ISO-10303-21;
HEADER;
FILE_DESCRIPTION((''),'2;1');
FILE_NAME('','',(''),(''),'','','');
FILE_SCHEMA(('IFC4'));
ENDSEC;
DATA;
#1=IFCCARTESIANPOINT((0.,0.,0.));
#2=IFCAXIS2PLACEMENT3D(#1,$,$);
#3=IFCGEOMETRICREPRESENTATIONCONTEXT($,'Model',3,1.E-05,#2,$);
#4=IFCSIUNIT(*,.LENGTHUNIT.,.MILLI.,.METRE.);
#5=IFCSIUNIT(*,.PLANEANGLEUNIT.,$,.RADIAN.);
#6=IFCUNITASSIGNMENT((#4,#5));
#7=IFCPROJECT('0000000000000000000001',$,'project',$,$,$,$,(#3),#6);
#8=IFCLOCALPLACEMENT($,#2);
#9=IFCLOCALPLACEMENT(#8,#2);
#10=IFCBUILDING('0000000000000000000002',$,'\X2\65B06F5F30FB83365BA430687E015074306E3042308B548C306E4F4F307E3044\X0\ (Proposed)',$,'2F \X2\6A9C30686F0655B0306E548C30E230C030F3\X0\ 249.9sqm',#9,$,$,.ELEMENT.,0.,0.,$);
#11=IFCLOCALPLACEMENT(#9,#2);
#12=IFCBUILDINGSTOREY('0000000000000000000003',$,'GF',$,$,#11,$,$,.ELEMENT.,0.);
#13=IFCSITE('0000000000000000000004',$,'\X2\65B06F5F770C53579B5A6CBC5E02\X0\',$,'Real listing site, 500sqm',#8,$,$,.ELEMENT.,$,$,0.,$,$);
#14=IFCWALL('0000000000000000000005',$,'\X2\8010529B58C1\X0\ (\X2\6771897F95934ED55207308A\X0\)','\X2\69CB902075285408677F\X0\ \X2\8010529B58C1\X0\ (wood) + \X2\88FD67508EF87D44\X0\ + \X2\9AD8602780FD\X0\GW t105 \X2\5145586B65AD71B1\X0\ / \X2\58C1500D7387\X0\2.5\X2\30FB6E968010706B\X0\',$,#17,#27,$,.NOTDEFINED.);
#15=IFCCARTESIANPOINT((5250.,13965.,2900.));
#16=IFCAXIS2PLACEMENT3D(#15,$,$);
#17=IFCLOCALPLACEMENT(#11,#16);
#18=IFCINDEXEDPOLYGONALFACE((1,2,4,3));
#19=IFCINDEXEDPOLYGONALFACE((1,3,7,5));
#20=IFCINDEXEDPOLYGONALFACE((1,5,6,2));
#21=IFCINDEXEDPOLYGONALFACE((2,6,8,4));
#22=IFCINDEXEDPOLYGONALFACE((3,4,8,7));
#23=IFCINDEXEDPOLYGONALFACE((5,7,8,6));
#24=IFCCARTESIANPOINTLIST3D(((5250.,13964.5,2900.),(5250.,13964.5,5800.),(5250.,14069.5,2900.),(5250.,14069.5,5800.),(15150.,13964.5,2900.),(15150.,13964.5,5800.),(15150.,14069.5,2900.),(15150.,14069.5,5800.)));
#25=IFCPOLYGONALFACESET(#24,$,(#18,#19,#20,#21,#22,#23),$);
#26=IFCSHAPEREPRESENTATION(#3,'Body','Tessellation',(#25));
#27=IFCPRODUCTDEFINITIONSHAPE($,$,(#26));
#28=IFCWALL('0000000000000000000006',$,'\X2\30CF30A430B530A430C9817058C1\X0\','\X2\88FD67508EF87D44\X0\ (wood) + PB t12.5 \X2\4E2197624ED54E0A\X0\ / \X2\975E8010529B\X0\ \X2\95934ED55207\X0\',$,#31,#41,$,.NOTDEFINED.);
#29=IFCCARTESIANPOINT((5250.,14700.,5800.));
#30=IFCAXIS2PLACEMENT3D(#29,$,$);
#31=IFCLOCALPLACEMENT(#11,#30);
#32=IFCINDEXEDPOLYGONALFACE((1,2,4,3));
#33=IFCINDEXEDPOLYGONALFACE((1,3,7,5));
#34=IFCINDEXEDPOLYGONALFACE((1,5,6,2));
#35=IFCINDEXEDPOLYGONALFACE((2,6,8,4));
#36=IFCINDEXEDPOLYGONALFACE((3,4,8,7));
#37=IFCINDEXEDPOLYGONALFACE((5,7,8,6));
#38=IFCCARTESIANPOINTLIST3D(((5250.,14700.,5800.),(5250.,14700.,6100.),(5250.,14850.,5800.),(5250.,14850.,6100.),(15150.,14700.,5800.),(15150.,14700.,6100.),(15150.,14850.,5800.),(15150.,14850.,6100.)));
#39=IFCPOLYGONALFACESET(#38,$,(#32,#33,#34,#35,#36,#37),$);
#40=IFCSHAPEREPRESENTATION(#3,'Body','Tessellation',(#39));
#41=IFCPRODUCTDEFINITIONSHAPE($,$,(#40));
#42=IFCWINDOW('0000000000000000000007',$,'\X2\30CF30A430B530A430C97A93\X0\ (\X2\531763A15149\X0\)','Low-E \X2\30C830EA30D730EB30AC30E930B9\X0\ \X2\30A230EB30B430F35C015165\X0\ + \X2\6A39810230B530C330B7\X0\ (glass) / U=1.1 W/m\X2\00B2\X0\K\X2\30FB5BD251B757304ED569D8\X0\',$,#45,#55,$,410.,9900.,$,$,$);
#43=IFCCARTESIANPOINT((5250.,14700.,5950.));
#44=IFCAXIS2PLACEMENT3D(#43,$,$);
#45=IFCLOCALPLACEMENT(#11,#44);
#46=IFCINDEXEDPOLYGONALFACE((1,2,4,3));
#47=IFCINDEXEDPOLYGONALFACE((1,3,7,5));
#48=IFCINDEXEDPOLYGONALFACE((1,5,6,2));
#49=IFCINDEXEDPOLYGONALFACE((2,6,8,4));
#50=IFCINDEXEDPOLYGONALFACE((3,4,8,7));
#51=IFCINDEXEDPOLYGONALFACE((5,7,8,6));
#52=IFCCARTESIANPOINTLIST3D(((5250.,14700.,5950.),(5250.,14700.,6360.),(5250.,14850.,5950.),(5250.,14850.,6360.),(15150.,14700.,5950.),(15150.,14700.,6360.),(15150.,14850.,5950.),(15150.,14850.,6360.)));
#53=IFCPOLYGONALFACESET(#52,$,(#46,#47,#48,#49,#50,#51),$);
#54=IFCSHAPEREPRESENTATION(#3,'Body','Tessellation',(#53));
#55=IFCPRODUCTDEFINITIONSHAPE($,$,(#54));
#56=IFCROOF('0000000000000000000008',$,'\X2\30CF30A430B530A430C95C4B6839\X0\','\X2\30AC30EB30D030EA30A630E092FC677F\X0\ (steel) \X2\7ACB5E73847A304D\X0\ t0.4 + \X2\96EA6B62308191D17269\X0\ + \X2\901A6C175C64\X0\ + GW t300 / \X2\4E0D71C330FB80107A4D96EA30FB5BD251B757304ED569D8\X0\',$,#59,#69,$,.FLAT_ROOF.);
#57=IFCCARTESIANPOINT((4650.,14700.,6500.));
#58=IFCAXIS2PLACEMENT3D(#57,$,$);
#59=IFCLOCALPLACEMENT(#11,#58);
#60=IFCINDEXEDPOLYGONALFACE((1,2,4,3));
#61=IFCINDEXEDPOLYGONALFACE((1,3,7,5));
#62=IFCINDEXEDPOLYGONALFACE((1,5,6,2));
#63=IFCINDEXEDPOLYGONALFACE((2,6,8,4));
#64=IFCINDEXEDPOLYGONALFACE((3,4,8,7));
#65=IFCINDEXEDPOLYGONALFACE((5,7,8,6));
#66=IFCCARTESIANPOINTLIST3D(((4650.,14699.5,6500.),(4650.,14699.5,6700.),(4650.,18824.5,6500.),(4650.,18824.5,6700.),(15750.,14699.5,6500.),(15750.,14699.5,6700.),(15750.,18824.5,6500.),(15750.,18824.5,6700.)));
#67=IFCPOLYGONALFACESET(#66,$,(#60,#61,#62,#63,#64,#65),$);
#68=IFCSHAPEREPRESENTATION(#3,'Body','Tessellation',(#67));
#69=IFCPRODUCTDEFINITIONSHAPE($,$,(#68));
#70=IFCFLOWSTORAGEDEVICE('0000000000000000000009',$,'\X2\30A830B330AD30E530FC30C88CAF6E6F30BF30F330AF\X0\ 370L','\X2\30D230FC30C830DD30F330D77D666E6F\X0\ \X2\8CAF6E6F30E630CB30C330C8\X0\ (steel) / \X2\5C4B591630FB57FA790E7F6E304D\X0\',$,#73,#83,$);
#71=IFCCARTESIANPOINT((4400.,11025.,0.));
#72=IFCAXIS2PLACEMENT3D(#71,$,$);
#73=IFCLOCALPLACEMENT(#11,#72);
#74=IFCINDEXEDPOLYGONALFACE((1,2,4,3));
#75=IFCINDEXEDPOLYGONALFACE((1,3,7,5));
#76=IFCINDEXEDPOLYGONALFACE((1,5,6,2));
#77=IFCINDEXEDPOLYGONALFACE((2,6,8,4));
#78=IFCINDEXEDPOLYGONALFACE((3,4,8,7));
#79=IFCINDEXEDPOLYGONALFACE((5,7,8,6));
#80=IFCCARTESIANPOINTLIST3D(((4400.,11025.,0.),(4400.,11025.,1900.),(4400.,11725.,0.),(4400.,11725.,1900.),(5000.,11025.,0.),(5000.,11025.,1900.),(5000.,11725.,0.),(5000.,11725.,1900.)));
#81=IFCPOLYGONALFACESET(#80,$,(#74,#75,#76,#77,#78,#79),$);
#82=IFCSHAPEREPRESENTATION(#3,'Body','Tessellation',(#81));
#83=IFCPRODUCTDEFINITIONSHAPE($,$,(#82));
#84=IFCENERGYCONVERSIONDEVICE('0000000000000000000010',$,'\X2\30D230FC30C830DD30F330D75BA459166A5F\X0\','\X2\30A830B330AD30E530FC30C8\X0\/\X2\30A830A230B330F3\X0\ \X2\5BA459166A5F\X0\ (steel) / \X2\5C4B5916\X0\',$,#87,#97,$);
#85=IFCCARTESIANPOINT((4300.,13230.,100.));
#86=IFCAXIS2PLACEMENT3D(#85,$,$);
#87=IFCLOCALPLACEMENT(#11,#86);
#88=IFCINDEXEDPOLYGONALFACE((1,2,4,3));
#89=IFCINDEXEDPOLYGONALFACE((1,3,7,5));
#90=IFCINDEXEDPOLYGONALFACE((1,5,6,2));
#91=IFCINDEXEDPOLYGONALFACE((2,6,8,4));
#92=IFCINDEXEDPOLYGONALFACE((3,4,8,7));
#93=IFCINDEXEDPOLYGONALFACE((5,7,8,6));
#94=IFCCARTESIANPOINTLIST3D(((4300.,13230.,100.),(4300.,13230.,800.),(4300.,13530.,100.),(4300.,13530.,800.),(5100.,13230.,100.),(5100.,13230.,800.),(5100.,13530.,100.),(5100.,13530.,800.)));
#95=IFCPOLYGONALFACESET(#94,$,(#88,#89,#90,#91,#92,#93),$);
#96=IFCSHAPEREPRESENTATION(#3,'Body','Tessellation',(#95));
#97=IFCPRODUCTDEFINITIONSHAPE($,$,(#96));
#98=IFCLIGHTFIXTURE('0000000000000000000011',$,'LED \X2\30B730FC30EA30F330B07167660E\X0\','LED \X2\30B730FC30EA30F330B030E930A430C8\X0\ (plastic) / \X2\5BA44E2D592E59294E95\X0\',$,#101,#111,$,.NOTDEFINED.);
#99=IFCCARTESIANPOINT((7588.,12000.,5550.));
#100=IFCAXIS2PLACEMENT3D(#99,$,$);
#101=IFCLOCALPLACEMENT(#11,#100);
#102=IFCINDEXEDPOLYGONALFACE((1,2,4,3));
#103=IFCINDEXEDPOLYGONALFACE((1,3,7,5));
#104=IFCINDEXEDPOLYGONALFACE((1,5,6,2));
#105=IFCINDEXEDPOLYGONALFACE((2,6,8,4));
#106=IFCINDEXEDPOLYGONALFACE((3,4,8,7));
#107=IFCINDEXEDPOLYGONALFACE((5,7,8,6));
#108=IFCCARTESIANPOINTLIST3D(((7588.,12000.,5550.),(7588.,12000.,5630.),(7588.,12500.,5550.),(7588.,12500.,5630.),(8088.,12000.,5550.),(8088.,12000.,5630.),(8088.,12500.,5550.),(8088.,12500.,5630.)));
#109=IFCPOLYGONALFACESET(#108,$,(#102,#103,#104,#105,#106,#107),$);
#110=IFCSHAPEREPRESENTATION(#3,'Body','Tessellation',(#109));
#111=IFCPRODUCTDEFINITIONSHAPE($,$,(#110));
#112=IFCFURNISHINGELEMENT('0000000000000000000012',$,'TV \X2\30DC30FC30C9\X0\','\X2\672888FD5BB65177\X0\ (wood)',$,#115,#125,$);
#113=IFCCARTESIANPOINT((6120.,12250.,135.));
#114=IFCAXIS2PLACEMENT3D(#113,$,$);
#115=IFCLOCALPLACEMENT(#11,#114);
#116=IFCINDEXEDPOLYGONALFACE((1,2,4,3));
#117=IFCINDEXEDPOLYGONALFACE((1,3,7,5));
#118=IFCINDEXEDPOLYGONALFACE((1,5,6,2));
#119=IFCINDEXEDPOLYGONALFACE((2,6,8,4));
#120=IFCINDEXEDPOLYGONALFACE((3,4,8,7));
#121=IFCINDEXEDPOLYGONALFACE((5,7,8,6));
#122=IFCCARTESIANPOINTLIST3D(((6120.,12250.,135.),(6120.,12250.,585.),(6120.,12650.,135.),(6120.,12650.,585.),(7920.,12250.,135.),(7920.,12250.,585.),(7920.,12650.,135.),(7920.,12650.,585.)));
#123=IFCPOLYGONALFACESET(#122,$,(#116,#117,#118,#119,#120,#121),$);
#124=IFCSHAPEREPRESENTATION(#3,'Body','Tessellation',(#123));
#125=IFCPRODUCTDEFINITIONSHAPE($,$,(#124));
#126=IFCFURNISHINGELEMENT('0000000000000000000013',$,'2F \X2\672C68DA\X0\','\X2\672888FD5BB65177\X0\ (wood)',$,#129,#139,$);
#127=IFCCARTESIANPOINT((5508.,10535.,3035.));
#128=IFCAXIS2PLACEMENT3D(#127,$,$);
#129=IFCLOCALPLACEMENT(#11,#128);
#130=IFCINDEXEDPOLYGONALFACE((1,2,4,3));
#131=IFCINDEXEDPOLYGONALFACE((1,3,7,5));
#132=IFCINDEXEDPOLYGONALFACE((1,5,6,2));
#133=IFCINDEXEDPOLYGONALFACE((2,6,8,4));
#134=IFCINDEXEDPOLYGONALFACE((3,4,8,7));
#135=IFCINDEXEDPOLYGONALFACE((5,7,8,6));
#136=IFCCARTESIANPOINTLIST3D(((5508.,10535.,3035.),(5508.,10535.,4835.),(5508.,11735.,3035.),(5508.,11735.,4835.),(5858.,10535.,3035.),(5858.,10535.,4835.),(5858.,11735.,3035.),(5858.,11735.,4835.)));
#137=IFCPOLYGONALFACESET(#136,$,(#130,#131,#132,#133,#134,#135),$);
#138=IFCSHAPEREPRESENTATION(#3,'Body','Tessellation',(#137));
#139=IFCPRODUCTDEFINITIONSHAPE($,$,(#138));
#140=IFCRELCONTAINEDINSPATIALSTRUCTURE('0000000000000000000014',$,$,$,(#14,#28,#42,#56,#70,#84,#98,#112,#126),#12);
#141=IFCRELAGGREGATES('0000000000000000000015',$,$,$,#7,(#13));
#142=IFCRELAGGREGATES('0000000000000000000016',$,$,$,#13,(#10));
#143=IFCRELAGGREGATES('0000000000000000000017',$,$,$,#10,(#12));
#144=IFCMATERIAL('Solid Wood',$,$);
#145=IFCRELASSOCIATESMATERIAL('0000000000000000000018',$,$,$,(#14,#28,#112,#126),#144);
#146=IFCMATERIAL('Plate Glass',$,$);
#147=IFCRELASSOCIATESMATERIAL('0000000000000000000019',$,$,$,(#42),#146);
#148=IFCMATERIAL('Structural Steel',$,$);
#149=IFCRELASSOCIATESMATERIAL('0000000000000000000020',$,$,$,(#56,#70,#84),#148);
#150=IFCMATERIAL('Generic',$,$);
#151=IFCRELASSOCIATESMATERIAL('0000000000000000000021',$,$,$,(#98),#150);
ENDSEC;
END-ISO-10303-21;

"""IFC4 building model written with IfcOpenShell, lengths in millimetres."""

from ifc_helpers import new_model, si_unit, frame, frame_2d, origin, place, context, project, spatial, rectangle, extrude, material, element, fill, save


model = new_model("IFC4")

# Units and contexts
model_context = context("Model", 3, precision=1e-05, world=origin())
ifc_project = project(units=[si_unit("LENGTHUNIT", "METRE", prefix="MILLI"), si_unit("PLANEANGLEUNIT", "RADIAN")], contexts=[model_context])

# Site, building, storey
site_placement = place(None, origin())
site = spatial("IfcSite", under=ifc_project, at=site_placement, Name="新潟県南魚沼市", ObjectType="Real listing site, 500sqm", CompositionType="ELEMENT", RefElevation=0.0)
building_placement = place(site_placement, origin())
building = spatial("IfcBuilding", under=site, at=building_placement, Name="新潟・茶室と縁側のある和の住まい (Proposed)", ObjectType="2F 檜と漆喰の和モダン 249.9sqm", CompositionType="ELEMENT", ElevationOfRefHeight=0.0, ElevationOfTerrain=0.0)
storey_placement = place(building_placement, origin())
storey = spatial("IfcBuildingStorey", under=building, at=storey_placement, Name="GF", CompositionType="ELEMENT", Elevation=0.0)

# Shared definitions
ifc_material_1 = material(Name="Solid Wood")

# Wall
wall_1_placement = place(storey_placement, frame((5250.0, 13965.0, 2900.0)))
element("IfcWall", 1, at=wall_1_placement, inside=storey, material=ifc_material_1, Name="耐力壁 (東西間仕切り)", Description="構造用合板 耐力壁 (wood) + 製材軸組 + 高性能GW t105 充填断熱 / 壁倍率2.5・準耐火", PredefinedType="NOTDEFINED", context=model_context, shape_type="SweptSolid", body=[
    extrude(rectangle(XDim=9900.0, YDim=105.0, at=frame_2d((4950.0, 52.0))), frame((5250.0, 13965.0, 2900.0)), (0.0, 0.0, 1.0), 2900.0),
])

# Wall, opening, window
wall_2_placement = place(storey_placement, frame((5250.0, 14700.0, 5800.0)))
wall_2 = element("IfcWall", 2, at=wall_2_placement, inside=storey, material=ifc_material_1, Name="ハイサイド腰壁", Description="製材軸組 (wood) + PB t12.5 両面仕上 / 非耐力 間仕切", PredefinedType="NOTDEFINED", context=model_context, shape_type="SweptSolid", body=[
    extrude(rectangle(XDim=9900.0, YDim=150.0, at=frame_2d((4950.0, 75.0))), frame((5250.0, 14700.0, 5800.0)), (0.0, 0.0, 1.0), 700.0),
])
opening_1_placement = place(storey_placement, frame((5250.0, 14700.0, 5950.0)))
opening_1 = element("IfcOpeningElement", 3, at=opening_1_placement, cuts=wall_2, PredefinedType="NOTDEFINED", context=model_context, shape_type="SweptSolid", body=[
    extrude(rectangle(XDim=9900.0, YDim=150.0, at=frame_2d((4950.0, 75.0))), frame((5250.0, 14700.0, 5950.0)), (0.0, 0.0, 1.0), 410.0),
])
ifc_material_2 = material(Name="Plate Glass")
window_placement = place(storey_placement, frame((5250.0, 14700.0, 5950.0)))
window = element("IfcWindow", 4, at=window_placement, inside=storey, material=ifc_material_2, Name="ハイサイド窓 (北採光)", Description="Low-E トリプルガラス アルゴン封入 + 樹脂サッシ (glass) / U=1.1 W/m²K・寒冷地仕様", OverallHeight=410.0, OverallWidth=9900.0, context=model_context, shape_type="SweptSolid", body=[
    extrude(rectangle(XDim=9900.0, YDim=150.0, at=frame_2d((4950.0, 75.0))), frame((5250.0, 14700.0, 5950.0)), (0.0, 0.0, 1.0), 410.0),
])
fill(opening_1, window)

# Roof
ifc_material_3 = material(Name="Structural Steel")
roof_placement = place(storey_placement, frame((4650.0, 14700.0, 6500.0)))
element("IfcRoof", 5, at=roof_placement, inside=storey, material=ifc_material_3, Name="ハイサイド屋根", Description="ガルバリウム鋼板 (steel) 立平葺き t0.4 + 雪止め金物 + 通気層 + GW t300 / 不燃・耐積雪・寒冷地仕様", PredefinedType="FLAT_ROOF", context=model_context, shape_type="SweptSolid", body=[
    extrude(rectangle(XDim=11100.0, YDim=4125.0, at=frame_2d((5550.0, 2062.0))), frame((4650.0, 14700.0, 6500.0)), (0.0, 0.0, 1.0), 200.0),
])

# Flow storage device
flow_storage_device_placement = place(storey_placement, frame((4400.0, 11025.0, 0.0)))
element("IfcFlowStorageDevice", 6, at=flow_storage_device_placement, inside=storey, material=ifc_material_3, Name="エコキュート貯湯タンク 370L", Description="ヒートポンプ給湯 貯湯ユニット (steel) / 屋外・基礎置き", context=model_context, shape_type="SweptSolid", body=[
    extrude(rectangle(XDim=600.0, YDim=700.0, at=frame_2d((300.0, 350.0))), frame((4400.0, 11025.0, 0.0)), (0.0, 0.0, 1.0), 1900.0),
])

# Energy conversion device
energy_conversion_device_placement = place(storey_placement, frame((4300.0, 13230.0, 100.0)))
element("IfcEnergyConversionDevice", 7, at=energy_conversion_device_placement, inside=storey, material=ifc_material_3, Name="ヒートポンプ室外機", Description="エコキュート/エアコン 室外機 (steel) / 屋外", context=model_context, shape_type="SweptSolid", body=[
    extrude(rectangle(XDim=800.0, YDim=300.0, at=frame_2d((400.0, 150.0))), frame((4300.0, 13230.0, 100.0)), (0.0, 0.0, 1.0), 700.0),
])

# Light fixture
ifc_material_4 = material(Name="Generic")
light_fixture_placement = place(storey_placement, frame((7588.0, 12000.0, 5550.0)))
element("IfcLightFixture", 8, at=light_fixture_placement, inside=storey, material=ifc_material_4, Name="LED シーリング照明", Description="LED シーリングライト (plastic) / 室中央天井", PredefinedType="NOTDEFINED", context=model_context, shape_type="SweptSolid", body=[
    extrude(rectangle(XDim=500.0, YDim=500.0, at=frame_2d((250.0, 250.0))), frame((7588.0, 12000.0, 5550.0)), (0.0, 0.0, 1.0), 80.0),
])

# Furnishing elements
furnishing_1_placement = place(storey_placement, frame((6120.0, 12250.0, 135.0)))
element("IfcFurnishingElement", 9, at=furnishing_1_placement, inside=storey, material=ifc_material_1, Name="TV ボード", Description="木製家具 (wood)", context=model_context, shape_type="SweptSolid", body=[
    extrude(rectangle(XDim=1800.0, YDim=400.0, at=frame_2d((900.0, 200.0))), frame((6120.0, 12250.0, 135.0)), (0.0, 0.0, 1.0), 450.0),
])
furnishing_2_placement = place(storey_placement, frame((5508.0, 10535.0, 3035.0)))
element("IfcFurnishingElement", 10, at=furnishing_2_placement, inside=storey, material=ifc_material_1, Name="2F 本棚", Description="木製家具 (wood)", context=model_context, shape_type="SweptSolid", body=[
    extrude(rectangle(XDim=350.0, YDim=1200.0, at=frame_2d((175.0, 600.0))), frame((5508.0, 10535.0, 3035.0)), (0.0, 0.0, 1.0), 1800.0),
])

save(model, "model.ifc")
